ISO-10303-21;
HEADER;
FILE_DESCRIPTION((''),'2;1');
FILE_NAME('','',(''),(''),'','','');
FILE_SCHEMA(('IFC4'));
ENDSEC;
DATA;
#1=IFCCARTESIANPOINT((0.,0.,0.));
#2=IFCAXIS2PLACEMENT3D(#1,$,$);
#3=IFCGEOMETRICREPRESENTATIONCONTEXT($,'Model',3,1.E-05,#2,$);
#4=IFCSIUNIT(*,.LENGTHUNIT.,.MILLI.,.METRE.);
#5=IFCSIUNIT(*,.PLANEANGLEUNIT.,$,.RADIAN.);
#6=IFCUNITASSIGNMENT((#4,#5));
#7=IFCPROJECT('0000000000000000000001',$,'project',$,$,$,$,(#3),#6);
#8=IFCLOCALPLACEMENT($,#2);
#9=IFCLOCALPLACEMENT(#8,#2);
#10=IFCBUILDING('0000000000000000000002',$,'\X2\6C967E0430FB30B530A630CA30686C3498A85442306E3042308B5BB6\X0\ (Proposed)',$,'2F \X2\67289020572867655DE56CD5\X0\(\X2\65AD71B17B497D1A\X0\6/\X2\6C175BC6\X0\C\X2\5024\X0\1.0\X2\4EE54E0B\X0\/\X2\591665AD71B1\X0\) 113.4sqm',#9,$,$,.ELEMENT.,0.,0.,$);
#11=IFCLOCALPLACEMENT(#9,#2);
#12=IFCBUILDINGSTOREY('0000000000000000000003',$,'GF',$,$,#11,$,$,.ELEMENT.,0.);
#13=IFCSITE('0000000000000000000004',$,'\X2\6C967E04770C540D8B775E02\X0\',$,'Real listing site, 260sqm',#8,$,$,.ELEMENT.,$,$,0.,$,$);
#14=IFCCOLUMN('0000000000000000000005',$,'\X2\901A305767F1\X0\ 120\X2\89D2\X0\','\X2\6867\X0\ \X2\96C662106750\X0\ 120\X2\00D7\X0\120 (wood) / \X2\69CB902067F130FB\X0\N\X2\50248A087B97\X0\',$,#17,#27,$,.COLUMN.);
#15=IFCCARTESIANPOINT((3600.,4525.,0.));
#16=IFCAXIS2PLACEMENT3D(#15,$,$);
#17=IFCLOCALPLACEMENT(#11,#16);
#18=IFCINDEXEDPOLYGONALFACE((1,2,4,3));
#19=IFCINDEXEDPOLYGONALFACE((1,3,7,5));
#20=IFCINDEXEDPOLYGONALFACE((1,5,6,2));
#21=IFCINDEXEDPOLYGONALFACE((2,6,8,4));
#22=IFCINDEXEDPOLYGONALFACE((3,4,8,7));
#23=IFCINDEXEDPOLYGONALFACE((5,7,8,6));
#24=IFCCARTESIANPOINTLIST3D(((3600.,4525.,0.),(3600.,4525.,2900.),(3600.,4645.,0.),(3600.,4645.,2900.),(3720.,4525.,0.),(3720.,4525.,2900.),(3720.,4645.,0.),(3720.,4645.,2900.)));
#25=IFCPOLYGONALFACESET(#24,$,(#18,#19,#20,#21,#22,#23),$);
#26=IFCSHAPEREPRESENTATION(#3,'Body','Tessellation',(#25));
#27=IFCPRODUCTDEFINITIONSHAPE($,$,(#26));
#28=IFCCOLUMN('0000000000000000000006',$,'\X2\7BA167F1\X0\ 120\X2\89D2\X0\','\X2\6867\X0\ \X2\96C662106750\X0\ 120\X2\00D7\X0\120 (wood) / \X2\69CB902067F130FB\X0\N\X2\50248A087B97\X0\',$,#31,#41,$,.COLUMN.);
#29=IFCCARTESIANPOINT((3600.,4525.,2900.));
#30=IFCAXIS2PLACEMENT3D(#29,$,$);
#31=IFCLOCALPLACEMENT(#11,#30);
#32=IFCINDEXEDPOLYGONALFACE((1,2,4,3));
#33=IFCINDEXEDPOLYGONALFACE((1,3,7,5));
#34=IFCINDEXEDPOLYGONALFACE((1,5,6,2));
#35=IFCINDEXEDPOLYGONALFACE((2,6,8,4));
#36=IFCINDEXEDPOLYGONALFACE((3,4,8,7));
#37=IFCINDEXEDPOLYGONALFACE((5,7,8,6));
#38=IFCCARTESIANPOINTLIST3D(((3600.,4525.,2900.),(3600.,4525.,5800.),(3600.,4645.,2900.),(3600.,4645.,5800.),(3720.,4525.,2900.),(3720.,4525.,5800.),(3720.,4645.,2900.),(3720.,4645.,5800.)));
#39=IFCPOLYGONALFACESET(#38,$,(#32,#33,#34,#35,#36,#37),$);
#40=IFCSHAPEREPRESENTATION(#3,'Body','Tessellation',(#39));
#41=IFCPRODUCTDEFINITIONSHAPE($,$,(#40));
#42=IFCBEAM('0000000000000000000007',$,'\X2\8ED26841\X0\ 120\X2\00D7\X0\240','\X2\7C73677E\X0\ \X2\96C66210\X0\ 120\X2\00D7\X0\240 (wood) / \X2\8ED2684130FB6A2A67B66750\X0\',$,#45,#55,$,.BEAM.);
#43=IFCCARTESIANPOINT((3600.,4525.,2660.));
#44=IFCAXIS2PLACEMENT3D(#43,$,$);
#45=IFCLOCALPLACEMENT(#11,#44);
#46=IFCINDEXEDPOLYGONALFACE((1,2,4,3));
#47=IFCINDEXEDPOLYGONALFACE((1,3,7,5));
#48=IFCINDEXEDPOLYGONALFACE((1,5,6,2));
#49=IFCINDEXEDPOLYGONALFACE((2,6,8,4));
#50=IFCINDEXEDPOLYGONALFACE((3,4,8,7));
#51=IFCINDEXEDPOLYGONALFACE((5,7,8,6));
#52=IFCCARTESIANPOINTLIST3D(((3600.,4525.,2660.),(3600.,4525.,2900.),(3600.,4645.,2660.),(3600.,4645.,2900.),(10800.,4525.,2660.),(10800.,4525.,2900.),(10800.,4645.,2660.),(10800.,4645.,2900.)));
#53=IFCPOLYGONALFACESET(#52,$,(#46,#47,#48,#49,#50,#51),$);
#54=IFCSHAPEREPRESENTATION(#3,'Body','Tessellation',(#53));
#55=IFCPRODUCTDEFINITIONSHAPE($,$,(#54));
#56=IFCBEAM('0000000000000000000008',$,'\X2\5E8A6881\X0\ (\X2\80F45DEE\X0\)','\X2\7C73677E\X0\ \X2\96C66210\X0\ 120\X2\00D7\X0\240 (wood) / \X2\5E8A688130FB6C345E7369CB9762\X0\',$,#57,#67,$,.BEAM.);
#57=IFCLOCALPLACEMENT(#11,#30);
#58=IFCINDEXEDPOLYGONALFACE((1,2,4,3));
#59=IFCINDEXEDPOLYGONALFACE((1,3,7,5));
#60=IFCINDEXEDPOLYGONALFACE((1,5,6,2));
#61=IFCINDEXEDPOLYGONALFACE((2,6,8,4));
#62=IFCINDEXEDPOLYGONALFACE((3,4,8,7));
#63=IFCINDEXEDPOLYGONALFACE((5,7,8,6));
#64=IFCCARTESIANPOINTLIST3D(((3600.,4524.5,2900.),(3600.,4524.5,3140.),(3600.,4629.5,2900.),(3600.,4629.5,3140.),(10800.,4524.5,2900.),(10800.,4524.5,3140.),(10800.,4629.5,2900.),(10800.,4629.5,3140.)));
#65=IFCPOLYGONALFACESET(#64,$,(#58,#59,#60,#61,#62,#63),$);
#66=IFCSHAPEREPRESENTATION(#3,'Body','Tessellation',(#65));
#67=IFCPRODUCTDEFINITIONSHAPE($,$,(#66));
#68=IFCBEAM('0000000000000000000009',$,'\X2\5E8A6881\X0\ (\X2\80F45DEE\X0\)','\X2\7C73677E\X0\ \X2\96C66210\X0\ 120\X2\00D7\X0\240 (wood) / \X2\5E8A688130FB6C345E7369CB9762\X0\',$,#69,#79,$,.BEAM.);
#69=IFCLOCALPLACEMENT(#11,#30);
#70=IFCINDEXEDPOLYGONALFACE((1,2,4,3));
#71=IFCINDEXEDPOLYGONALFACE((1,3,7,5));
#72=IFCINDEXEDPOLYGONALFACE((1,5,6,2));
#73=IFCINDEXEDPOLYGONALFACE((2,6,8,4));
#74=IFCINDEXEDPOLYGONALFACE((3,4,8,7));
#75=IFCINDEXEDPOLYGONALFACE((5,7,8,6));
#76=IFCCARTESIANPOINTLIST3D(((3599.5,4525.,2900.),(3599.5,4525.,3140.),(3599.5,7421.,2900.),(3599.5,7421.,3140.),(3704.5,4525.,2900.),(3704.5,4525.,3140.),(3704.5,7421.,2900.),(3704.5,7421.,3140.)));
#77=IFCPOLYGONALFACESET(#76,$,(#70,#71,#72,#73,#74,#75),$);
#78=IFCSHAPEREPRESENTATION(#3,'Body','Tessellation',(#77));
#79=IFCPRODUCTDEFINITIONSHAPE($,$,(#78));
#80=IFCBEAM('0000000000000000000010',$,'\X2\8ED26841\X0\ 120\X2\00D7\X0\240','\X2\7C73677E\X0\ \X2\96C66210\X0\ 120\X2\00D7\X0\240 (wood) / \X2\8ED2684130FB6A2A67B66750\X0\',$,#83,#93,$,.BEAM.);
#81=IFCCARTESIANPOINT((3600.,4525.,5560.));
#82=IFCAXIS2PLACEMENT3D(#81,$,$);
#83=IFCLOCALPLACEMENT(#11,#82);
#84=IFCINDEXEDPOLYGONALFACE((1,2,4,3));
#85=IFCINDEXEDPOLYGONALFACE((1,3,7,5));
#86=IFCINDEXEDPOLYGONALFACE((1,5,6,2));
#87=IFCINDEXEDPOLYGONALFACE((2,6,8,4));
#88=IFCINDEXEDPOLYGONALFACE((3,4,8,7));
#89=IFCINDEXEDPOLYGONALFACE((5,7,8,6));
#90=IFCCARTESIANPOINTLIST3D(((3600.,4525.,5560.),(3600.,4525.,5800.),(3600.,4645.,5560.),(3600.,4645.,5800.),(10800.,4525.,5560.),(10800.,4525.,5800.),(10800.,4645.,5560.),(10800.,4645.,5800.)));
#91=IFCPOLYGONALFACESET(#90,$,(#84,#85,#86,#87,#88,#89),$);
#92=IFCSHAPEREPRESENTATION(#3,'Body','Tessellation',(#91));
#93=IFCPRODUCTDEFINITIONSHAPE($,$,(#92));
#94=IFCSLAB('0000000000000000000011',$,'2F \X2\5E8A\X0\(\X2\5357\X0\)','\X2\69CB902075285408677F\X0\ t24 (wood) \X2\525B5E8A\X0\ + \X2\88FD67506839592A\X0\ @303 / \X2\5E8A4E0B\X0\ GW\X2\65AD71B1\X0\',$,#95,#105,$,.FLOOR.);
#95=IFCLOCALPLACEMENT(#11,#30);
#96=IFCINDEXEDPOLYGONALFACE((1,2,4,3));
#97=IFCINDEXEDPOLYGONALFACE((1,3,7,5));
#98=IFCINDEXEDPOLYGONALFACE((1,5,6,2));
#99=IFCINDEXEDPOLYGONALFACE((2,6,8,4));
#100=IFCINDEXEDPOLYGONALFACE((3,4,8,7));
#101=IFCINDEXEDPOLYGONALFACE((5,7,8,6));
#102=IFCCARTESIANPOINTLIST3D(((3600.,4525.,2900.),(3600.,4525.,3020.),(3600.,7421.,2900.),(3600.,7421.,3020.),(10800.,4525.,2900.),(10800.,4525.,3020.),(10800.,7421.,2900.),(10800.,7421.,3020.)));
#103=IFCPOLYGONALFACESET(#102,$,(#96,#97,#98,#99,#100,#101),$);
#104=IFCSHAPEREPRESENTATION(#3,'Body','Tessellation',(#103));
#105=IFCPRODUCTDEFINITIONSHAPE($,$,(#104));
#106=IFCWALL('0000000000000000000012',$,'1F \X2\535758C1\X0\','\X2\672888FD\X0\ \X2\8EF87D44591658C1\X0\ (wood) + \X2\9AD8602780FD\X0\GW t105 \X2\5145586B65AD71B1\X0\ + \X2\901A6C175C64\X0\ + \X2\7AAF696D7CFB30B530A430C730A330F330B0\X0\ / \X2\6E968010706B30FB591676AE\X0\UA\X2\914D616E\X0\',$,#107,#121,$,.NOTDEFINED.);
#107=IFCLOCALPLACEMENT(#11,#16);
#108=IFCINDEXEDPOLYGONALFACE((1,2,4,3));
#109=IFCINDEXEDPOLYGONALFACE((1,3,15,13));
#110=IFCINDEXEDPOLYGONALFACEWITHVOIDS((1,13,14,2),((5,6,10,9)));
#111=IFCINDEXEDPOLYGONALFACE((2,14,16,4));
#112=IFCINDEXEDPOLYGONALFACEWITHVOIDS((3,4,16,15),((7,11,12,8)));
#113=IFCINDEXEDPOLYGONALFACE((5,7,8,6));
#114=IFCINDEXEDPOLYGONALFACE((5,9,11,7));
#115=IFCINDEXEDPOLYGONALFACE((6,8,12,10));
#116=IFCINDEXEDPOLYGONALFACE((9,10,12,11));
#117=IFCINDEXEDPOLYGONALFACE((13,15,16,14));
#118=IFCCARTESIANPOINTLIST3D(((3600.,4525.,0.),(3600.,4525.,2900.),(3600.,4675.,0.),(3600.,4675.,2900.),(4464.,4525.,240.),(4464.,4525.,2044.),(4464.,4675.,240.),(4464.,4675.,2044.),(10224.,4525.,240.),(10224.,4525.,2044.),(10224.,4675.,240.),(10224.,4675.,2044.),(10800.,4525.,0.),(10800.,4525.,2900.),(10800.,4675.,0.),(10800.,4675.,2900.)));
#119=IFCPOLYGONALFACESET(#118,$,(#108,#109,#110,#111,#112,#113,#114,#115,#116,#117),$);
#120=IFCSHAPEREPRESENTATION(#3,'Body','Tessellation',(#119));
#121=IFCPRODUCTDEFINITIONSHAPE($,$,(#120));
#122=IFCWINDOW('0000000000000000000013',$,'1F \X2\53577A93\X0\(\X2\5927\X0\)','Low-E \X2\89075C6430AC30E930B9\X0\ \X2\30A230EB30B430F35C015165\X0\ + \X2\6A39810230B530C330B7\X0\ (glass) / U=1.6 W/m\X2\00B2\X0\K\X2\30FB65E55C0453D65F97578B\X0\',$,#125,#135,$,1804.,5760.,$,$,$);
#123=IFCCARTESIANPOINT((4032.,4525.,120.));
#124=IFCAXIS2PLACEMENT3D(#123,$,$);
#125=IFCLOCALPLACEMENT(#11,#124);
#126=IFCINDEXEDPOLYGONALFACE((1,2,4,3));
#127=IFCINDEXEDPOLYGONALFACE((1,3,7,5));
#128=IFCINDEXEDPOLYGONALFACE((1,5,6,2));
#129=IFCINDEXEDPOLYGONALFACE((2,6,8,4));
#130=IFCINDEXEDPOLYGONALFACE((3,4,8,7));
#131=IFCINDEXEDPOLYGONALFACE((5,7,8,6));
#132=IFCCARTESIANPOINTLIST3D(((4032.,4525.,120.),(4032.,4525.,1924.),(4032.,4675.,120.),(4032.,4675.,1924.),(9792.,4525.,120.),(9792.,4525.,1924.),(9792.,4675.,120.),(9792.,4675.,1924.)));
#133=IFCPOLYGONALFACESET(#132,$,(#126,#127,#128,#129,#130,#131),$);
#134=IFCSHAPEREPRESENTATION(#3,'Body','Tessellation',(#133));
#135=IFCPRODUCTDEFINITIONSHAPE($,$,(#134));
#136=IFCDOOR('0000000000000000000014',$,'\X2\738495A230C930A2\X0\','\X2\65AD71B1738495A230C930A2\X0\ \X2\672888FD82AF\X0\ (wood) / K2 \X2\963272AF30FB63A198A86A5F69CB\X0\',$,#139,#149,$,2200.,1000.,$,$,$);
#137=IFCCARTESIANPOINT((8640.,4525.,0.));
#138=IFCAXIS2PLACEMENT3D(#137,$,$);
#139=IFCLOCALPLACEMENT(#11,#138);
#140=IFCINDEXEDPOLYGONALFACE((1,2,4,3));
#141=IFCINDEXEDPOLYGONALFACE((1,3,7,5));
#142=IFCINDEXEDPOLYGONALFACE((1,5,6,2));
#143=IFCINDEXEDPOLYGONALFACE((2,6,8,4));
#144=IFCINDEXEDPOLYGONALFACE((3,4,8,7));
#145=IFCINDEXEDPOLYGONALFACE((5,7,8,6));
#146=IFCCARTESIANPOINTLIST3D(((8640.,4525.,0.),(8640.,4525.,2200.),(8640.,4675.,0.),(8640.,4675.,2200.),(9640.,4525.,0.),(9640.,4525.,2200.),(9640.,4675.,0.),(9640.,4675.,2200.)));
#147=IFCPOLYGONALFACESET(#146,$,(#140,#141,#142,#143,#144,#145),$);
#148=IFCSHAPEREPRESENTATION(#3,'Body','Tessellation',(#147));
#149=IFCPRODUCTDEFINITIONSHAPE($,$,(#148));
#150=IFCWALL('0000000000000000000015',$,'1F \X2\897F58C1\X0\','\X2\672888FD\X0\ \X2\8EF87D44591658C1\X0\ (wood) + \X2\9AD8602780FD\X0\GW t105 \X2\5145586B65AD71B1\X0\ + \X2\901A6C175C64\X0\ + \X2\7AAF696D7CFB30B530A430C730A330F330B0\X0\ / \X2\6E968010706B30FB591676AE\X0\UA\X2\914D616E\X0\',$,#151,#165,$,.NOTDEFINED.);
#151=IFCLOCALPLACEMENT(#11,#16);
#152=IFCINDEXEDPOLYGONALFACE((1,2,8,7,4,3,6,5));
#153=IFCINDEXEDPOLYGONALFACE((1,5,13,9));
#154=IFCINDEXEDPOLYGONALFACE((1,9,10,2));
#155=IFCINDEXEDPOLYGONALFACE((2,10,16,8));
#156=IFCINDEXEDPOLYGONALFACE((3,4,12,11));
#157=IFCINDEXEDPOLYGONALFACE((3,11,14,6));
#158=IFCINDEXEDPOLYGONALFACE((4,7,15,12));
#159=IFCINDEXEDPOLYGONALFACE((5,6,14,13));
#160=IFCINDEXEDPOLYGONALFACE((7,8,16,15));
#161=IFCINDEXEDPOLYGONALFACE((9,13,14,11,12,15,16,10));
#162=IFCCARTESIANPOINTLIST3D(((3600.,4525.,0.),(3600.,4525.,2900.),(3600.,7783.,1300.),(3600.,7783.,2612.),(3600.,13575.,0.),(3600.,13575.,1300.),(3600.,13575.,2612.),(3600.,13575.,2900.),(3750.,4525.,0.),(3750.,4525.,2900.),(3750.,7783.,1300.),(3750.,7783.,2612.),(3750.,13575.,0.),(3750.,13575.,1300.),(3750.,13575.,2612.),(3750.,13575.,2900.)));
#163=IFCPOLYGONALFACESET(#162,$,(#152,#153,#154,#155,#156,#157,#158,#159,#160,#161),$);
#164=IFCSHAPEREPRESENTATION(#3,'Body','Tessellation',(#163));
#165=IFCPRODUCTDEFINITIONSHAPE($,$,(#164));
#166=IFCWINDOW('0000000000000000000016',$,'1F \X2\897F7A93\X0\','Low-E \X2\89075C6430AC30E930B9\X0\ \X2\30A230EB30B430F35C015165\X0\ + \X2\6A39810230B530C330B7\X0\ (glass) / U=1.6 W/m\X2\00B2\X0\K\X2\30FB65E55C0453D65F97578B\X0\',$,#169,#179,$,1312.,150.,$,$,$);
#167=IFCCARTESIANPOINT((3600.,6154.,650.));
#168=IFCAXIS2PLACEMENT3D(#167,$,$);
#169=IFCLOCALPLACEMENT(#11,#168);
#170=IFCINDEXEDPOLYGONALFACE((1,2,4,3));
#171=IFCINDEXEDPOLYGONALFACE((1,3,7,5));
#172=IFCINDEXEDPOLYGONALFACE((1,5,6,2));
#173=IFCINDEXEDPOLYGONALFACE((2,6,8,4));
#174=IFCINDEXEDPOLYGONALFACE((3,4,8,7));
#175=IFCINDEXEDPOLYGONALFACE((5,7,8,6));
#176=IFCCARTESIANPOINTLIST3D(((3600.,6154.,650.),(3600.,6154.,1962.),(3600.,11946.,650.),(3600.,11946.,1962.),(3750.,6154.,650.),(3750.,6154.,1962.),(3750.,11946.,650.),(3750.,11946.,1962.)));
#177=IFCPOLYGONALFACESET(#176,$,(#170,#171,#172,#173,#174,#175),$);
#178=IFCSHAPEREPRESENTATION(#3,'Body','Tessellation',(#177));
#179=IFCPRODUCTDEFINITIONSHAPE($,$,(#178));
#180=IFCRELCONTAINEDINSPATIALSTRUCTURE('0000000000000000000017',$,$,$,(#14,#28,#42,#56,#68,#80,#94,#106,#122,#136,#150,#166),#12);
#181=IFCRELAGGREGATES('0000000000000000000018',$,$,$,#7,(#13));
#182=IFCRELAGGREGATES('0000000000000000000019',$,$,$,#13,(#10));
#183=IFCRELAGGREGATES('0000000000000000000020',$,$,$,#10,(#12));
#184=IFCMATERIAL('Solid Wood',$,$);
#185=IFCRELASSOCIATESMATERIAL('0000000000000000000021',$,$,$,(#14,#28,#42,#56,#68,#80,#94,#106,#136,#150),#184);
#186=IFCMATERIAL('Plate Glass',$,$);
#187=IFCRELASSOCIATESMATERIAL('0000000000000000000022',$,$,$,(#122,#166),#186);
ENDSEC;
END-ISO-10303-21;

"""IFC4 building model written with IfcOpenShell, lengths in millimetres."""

from ifc_helpers import new_model, si_unit, frame, frame_2d, origin, place, context, project, spatial, rectangle, extrude, material, element, fill, save


model = new_model("IFC4")

# Units and contexts
model_context = context("Model", 3, precision=1e-05, world=origin())
ifc_project = project(units=[si_unit("LENGTHUNIT", "METRE", prefix="MILLI"), si_unit("PLANEANGLEUNIT", "RADIAN")], contexts=[model_context])

# Site, building, storey
site_placement = place(None, origin())
site = spatial("IfcSite", under=ifc_project, at=site_placement, Name="沖縄県名護市", ObjectType="Real listing site, 260sqm", CompositionType="ELEMENT", RefElevation=0.0)
building_placement = place(site_placement, origin())
building = spatial("IfcBuilding", under=site, at=building_placement, Name="沖縄・サウナと水風呂のある家 (Proposed)", ObjectType="2F 木造在来工法(断熱等級6/気密C値1.0以下/外断熱) 113.4sqm", CompositionType="ELEMENT", ElevationOfRefHeight=0.0, ElevationOfTerrain=0.0)
storey_placement = place(building_placement, origin())
storey = spatial("IfcBuildingStorey", under=building, at=storey_placement, Name="GF", CompositionType="ELEMENT", Elevation=0.0)

# Columns
ifc_material_1 = material(Name="Solid Wood")
column_1_placement = place(storey_placement, frame((3600.0, 4525.0, 0.0)))
element("IfcColumn", 1, at=column_1_placement, inside=storey, material=ifc_material_1, Name="通し柱 120角", Description="桧 集成材 120×120 (wood) / 構造柱・N値計算", PredefinedType="COLUMN", context=model_context, shape_type="SweptSolid", body=[
    extrude(rectangle(XDim=120.0, YDim=120.0, at=frame_2d((60.0, 60.0))), frame((3600.0, 4525.0, 0.0)), (0.0, 0.0, 1.0), 2900.0),
])
column_2_placement = place(storey_placement, frame((3600.0, 4525.0, 2900.0)))
element("IfcColumn", 2, at=column_2_placement, inside=storey, material=ifc_material_1, Name="管柱 120角", Description="桧 集成材 120×120 (wood) / 構造柱・N値計算", PredefinedType="COLUMN", context=model_context, shape_type="SweptSolid", body=[
    extrude(rectangle(XDim=120.0, YDim=120.0, at=frame_2d((60.0, 60.0))), frame((3600.0, 4525.0, 2900.0)), (0.0, 0.0, 1.0), 2900.0),
])

# Beams
beam_1_placement = place(storey_placement, frame((3600.0, 4525.0, 2660.0)))
element("IfcBeam", 3, at=beam_1_placement, inside=storey, material=ifc_material_1, Name="軒桁 120×240", Description="米松 集成 120×240 (wood) / 軒桁・横架材", PredefinedType="BEAM", context=model_context, shape_type="SweptSolid", body=[
    extrude(rectangle(XDim=7200.0, YDim=120.0, at=frame_2d((3600.0, 60.0))), frame((3600.0, 4525.0, 2660.0)), (0.0, 0.0, 1.0), 240.0),
])
beam_2_placement = place(storey_placement, frame((3600.0, 4525.0, 2900.0)))
element("IfcBeam", 4, at=beam_2_placement, inside=storey, material=ifc_material_1, Name="床梁 (胴差)", Description="米松 集成 120×240 (wood) / 床梁・水平構面", PredefinedType="BEAM", context=model_context, shape_type="SweptSolid", body=[
    extrude(rectangle(XDim=7200.0, YDim=105.0, at=frame_2d((3600.0, 52.0))), frame((3600.0, 4525.0, 2900.0)), (0.0, 0.0, 1.0), 240.0),
])
beam_3_placement = place(storey_placement, frame((3600.0, 4525.0, 2900.0)))
element("IfcBeam", 5, at=beam_3_placement, inside=storey, material=ifc_material_1, Name="床梁 (胴差)", Description="米松 集成 120×240 (wood) / 床梁・水平構面", PredefinedType="BEAM", context=model_context, shape_type="SweptSolid", body=[
    extrude(rectangle(XDim=105.0, YDim=2896.0, at=frame_2d((52.0, 1448.0))), frame((3600.0, 4525.0, 2900.0)), (0.0, 0.0, 1.0), 240.0),
])
beam_4_placement = place(storey_placement, frame((3600.0, 4525.0, 5560.0)))
element("IfcBeam", 6, at=beam_4_placement, inside=storey, material=ifc_material_1, Name="軒桁 120×240", Description="米松 集成 120×240 (wood) / 軒桁・横架材", PredefinedType="BEAM", context=model_context, shape_type="SweptSolid", body=[
    extrude(rectangle(XDim=7200.0, YDim=120.0, at=frame_2d((3600.0, 60.0))), frame((3600.0, 4525.0, 5560.0)), (0.0, 0.0, 1.0), 240.0),
])

# Slab
slab_1_placement = place(storey_placement, frame((3600.0, 4525.0, 2900.0)))
element("IfcSlab", 7, at=slab_1_placement, inside=storey, material=ifc_material_1, Name="2F 床(南)", Description="構造用合板 t24 (wood) 剛床 + 製材根太 @303 / 床下 GW断熱", PredefinedType="FLOOR", context=model_context, shape_type="SweptSolid", body=[
    extrude(rectangle(XDim=7200.0, YDim=2896.0, at=frame_2d((3600.0, 1448.0))), frame((3600.0, 4525.0, 2900.0)), (0.0, 0.0, 1.0), 120.0),
])

# Wall, openings, window, door
wall_1_placement = place(storey_placement, frame((3600.0, 4525.0, 0.0)))
wall_1 = element("IfcWall", 8, at=wall_1_placement, inside=storey, material=ifc_material_1, Name="1F 南壁", Description="木製 軸組外壁 (wood) + 高性能GW t105 充填断熱 + 通気層 + 窯業系サイディング / 準耐火・外皮UA配慮", PredefinedType="NOTDEFINED", context=model_context, shape_type="SweptSolid", body=[
    extrude(rectangle(XDim=7200.0, YDim=150.0, at=frame_2d((3600.0, 75.0))), frame((3600.0, 4525.0, 0.0)), (0.0, 0.0, 1.0), 2900.0),
])
opening_1_placement = place(storey_placement, frame((4032.0, 4525.0, 120.0)))
opening_1 = element("IfcOpeningElement", 9, at=opening_1_placement, cuts=wall_1, PredefinedType="NOTDEFINED", context=model_context, shape_type="SweptSolid", body=[
    extrude(rectangle(XDim=5760.0, YDim=150.0, at=frame_2d((2880.0, 75.0))), frame((4032.0, 4525.0, 120.0)), (0.0, 0.0, 1.0), 1804.0),
])
opening_2_placement = place(storey_placement, frame((8640.0, 4525.0, 0.0)))
opening_2 = element("IfcOpeningElement", 10, at=opening_2_placement, cuts=wall_1, PredefinedType="NOTDEFINED", context=model_context, shape_type="SweptSolid", body=[
    extrude(rectangle(XDim=1000.0, YDim=150.0, at=frame_2d((500.0, 75.0))), frame((8640.0, 4525.0, 0.0)), (0.0, 0.0, 1.0), 2200.0),
])
ifc_material_2 = material(Name="Plate Glass")
window_1_placement = place(storey_placement, frame((4032.0, 4525.0, 120.0)))
window_1 = element("IfcWindow", 11, at=window_1_placement, inside=storey, material=ifc_material_2, Name="1F 南窓(大)", Description="Low-E 複層ガラス アルゴン封入 + 樹脂サッシ (glass) / U=1.6 W/m²K・日射取得型", OverallHeight=1804.0, OverallWidth=5760.0, context=model_context, shape_type="SweptSolid", body=[
    extrude(rectangle(XDim=5760.0, YDim=150.0, at=frame_2d((2880.0, 75.0))), frame((4032.0, 4525.0, 120.0)), (0.0, 0.0, 1.0), 1804.0),
])
fill(opening_1, window_1)
door_placement = place(storey_placement, frame((8640.0, 4525.0, 0.0)))
door = element("IfcDoor", 12, at=door_placement, inside=storey, material=ifc_material_1, Name="玄関ドア", Description="断熱玄関ドア 木製芯 (wood) / K2 防犯・採風機構", OverallHeight=2200.0, OverallWidth=1000.0, context=model_context, shape_type="SweptSolid", body=[
    extrude(rectangle(XDim=1000.0, YDim=150.0, at=frame_2d((500.0, 75.0))), frame((8640.0, 4525.0, 0.0)), (0.0, 0.0, 1.0), 2200.0),
])
fill(opening_2, door)

# Wall, opening, window
wall_2_placement = place(storey_placement, frame((3600.0, 4525.0, 0.0)))
wall_2 = element("IfcWall", 13, at=wall_2_placement, inside=storey, material=ifc_material_1, Name="1F 西壁", Description="木製 軸組外壁 (wood) + 高性能GW t105 充填断熱 + 通気層 + 窯業系サイディング / 準耐火・外皮UA配慮", PredefinedType="NOTDEFINED", context=model_context, shape_type="SweptSolid", body=[
    extrude(rectangle(XDim=150.0, YDim=9050.0, at=frame_2d((75.0, 4525.0))), frame((3600.0, 4525.0, 0.0)), (0.0, 0.0, 1.0), 2900.0),
])
opening_3_placement = place(storey_placement, frame((3600.0, 6154.0, 650.0)))
opening_3 = element("IfcOpeningElement", 14, at=opening_3_placement, cuts=wall_2, PredefinedType="NOTDEFINED", context=model_context, shape_type="SweptSolid", body=[
    extrude(rectangle(XDim=150.0, YDim=5792.0, at=frame_2d((75.0, 2896.0))), frame((3600.0, 6154.0, 650.0)), (0.0, 0.0, 1.0), 1312.0),
])
window_2_placement = place(storey_placement, frame((3600.0, 6154.0, 650.0)))
window_2 = element("IfcWindow", 15, at=window_2_placement, inside=storey, material=ifc_material_2, Name="1F 西窓", Description="Low-E 複層ガラス アルゴン封入 + 樹脂サッシ (glass) / U=1.6 W/m²K・日射取得型", OverallHeight=1312.0, OverallWidth=150.0, context=model_context, shape_type="SweptSolid", body=[
    extrude(rectangle(XDim=150.0, YDim=5792.0, at=frame_2d((75.0, 2896.0))), frame((3600.0, 6154.0, 650.0)), (0.0, 0.0, 1.0), 1312.0),
])
fill(opening_3, window_2)

save(model, "model.ifc")
